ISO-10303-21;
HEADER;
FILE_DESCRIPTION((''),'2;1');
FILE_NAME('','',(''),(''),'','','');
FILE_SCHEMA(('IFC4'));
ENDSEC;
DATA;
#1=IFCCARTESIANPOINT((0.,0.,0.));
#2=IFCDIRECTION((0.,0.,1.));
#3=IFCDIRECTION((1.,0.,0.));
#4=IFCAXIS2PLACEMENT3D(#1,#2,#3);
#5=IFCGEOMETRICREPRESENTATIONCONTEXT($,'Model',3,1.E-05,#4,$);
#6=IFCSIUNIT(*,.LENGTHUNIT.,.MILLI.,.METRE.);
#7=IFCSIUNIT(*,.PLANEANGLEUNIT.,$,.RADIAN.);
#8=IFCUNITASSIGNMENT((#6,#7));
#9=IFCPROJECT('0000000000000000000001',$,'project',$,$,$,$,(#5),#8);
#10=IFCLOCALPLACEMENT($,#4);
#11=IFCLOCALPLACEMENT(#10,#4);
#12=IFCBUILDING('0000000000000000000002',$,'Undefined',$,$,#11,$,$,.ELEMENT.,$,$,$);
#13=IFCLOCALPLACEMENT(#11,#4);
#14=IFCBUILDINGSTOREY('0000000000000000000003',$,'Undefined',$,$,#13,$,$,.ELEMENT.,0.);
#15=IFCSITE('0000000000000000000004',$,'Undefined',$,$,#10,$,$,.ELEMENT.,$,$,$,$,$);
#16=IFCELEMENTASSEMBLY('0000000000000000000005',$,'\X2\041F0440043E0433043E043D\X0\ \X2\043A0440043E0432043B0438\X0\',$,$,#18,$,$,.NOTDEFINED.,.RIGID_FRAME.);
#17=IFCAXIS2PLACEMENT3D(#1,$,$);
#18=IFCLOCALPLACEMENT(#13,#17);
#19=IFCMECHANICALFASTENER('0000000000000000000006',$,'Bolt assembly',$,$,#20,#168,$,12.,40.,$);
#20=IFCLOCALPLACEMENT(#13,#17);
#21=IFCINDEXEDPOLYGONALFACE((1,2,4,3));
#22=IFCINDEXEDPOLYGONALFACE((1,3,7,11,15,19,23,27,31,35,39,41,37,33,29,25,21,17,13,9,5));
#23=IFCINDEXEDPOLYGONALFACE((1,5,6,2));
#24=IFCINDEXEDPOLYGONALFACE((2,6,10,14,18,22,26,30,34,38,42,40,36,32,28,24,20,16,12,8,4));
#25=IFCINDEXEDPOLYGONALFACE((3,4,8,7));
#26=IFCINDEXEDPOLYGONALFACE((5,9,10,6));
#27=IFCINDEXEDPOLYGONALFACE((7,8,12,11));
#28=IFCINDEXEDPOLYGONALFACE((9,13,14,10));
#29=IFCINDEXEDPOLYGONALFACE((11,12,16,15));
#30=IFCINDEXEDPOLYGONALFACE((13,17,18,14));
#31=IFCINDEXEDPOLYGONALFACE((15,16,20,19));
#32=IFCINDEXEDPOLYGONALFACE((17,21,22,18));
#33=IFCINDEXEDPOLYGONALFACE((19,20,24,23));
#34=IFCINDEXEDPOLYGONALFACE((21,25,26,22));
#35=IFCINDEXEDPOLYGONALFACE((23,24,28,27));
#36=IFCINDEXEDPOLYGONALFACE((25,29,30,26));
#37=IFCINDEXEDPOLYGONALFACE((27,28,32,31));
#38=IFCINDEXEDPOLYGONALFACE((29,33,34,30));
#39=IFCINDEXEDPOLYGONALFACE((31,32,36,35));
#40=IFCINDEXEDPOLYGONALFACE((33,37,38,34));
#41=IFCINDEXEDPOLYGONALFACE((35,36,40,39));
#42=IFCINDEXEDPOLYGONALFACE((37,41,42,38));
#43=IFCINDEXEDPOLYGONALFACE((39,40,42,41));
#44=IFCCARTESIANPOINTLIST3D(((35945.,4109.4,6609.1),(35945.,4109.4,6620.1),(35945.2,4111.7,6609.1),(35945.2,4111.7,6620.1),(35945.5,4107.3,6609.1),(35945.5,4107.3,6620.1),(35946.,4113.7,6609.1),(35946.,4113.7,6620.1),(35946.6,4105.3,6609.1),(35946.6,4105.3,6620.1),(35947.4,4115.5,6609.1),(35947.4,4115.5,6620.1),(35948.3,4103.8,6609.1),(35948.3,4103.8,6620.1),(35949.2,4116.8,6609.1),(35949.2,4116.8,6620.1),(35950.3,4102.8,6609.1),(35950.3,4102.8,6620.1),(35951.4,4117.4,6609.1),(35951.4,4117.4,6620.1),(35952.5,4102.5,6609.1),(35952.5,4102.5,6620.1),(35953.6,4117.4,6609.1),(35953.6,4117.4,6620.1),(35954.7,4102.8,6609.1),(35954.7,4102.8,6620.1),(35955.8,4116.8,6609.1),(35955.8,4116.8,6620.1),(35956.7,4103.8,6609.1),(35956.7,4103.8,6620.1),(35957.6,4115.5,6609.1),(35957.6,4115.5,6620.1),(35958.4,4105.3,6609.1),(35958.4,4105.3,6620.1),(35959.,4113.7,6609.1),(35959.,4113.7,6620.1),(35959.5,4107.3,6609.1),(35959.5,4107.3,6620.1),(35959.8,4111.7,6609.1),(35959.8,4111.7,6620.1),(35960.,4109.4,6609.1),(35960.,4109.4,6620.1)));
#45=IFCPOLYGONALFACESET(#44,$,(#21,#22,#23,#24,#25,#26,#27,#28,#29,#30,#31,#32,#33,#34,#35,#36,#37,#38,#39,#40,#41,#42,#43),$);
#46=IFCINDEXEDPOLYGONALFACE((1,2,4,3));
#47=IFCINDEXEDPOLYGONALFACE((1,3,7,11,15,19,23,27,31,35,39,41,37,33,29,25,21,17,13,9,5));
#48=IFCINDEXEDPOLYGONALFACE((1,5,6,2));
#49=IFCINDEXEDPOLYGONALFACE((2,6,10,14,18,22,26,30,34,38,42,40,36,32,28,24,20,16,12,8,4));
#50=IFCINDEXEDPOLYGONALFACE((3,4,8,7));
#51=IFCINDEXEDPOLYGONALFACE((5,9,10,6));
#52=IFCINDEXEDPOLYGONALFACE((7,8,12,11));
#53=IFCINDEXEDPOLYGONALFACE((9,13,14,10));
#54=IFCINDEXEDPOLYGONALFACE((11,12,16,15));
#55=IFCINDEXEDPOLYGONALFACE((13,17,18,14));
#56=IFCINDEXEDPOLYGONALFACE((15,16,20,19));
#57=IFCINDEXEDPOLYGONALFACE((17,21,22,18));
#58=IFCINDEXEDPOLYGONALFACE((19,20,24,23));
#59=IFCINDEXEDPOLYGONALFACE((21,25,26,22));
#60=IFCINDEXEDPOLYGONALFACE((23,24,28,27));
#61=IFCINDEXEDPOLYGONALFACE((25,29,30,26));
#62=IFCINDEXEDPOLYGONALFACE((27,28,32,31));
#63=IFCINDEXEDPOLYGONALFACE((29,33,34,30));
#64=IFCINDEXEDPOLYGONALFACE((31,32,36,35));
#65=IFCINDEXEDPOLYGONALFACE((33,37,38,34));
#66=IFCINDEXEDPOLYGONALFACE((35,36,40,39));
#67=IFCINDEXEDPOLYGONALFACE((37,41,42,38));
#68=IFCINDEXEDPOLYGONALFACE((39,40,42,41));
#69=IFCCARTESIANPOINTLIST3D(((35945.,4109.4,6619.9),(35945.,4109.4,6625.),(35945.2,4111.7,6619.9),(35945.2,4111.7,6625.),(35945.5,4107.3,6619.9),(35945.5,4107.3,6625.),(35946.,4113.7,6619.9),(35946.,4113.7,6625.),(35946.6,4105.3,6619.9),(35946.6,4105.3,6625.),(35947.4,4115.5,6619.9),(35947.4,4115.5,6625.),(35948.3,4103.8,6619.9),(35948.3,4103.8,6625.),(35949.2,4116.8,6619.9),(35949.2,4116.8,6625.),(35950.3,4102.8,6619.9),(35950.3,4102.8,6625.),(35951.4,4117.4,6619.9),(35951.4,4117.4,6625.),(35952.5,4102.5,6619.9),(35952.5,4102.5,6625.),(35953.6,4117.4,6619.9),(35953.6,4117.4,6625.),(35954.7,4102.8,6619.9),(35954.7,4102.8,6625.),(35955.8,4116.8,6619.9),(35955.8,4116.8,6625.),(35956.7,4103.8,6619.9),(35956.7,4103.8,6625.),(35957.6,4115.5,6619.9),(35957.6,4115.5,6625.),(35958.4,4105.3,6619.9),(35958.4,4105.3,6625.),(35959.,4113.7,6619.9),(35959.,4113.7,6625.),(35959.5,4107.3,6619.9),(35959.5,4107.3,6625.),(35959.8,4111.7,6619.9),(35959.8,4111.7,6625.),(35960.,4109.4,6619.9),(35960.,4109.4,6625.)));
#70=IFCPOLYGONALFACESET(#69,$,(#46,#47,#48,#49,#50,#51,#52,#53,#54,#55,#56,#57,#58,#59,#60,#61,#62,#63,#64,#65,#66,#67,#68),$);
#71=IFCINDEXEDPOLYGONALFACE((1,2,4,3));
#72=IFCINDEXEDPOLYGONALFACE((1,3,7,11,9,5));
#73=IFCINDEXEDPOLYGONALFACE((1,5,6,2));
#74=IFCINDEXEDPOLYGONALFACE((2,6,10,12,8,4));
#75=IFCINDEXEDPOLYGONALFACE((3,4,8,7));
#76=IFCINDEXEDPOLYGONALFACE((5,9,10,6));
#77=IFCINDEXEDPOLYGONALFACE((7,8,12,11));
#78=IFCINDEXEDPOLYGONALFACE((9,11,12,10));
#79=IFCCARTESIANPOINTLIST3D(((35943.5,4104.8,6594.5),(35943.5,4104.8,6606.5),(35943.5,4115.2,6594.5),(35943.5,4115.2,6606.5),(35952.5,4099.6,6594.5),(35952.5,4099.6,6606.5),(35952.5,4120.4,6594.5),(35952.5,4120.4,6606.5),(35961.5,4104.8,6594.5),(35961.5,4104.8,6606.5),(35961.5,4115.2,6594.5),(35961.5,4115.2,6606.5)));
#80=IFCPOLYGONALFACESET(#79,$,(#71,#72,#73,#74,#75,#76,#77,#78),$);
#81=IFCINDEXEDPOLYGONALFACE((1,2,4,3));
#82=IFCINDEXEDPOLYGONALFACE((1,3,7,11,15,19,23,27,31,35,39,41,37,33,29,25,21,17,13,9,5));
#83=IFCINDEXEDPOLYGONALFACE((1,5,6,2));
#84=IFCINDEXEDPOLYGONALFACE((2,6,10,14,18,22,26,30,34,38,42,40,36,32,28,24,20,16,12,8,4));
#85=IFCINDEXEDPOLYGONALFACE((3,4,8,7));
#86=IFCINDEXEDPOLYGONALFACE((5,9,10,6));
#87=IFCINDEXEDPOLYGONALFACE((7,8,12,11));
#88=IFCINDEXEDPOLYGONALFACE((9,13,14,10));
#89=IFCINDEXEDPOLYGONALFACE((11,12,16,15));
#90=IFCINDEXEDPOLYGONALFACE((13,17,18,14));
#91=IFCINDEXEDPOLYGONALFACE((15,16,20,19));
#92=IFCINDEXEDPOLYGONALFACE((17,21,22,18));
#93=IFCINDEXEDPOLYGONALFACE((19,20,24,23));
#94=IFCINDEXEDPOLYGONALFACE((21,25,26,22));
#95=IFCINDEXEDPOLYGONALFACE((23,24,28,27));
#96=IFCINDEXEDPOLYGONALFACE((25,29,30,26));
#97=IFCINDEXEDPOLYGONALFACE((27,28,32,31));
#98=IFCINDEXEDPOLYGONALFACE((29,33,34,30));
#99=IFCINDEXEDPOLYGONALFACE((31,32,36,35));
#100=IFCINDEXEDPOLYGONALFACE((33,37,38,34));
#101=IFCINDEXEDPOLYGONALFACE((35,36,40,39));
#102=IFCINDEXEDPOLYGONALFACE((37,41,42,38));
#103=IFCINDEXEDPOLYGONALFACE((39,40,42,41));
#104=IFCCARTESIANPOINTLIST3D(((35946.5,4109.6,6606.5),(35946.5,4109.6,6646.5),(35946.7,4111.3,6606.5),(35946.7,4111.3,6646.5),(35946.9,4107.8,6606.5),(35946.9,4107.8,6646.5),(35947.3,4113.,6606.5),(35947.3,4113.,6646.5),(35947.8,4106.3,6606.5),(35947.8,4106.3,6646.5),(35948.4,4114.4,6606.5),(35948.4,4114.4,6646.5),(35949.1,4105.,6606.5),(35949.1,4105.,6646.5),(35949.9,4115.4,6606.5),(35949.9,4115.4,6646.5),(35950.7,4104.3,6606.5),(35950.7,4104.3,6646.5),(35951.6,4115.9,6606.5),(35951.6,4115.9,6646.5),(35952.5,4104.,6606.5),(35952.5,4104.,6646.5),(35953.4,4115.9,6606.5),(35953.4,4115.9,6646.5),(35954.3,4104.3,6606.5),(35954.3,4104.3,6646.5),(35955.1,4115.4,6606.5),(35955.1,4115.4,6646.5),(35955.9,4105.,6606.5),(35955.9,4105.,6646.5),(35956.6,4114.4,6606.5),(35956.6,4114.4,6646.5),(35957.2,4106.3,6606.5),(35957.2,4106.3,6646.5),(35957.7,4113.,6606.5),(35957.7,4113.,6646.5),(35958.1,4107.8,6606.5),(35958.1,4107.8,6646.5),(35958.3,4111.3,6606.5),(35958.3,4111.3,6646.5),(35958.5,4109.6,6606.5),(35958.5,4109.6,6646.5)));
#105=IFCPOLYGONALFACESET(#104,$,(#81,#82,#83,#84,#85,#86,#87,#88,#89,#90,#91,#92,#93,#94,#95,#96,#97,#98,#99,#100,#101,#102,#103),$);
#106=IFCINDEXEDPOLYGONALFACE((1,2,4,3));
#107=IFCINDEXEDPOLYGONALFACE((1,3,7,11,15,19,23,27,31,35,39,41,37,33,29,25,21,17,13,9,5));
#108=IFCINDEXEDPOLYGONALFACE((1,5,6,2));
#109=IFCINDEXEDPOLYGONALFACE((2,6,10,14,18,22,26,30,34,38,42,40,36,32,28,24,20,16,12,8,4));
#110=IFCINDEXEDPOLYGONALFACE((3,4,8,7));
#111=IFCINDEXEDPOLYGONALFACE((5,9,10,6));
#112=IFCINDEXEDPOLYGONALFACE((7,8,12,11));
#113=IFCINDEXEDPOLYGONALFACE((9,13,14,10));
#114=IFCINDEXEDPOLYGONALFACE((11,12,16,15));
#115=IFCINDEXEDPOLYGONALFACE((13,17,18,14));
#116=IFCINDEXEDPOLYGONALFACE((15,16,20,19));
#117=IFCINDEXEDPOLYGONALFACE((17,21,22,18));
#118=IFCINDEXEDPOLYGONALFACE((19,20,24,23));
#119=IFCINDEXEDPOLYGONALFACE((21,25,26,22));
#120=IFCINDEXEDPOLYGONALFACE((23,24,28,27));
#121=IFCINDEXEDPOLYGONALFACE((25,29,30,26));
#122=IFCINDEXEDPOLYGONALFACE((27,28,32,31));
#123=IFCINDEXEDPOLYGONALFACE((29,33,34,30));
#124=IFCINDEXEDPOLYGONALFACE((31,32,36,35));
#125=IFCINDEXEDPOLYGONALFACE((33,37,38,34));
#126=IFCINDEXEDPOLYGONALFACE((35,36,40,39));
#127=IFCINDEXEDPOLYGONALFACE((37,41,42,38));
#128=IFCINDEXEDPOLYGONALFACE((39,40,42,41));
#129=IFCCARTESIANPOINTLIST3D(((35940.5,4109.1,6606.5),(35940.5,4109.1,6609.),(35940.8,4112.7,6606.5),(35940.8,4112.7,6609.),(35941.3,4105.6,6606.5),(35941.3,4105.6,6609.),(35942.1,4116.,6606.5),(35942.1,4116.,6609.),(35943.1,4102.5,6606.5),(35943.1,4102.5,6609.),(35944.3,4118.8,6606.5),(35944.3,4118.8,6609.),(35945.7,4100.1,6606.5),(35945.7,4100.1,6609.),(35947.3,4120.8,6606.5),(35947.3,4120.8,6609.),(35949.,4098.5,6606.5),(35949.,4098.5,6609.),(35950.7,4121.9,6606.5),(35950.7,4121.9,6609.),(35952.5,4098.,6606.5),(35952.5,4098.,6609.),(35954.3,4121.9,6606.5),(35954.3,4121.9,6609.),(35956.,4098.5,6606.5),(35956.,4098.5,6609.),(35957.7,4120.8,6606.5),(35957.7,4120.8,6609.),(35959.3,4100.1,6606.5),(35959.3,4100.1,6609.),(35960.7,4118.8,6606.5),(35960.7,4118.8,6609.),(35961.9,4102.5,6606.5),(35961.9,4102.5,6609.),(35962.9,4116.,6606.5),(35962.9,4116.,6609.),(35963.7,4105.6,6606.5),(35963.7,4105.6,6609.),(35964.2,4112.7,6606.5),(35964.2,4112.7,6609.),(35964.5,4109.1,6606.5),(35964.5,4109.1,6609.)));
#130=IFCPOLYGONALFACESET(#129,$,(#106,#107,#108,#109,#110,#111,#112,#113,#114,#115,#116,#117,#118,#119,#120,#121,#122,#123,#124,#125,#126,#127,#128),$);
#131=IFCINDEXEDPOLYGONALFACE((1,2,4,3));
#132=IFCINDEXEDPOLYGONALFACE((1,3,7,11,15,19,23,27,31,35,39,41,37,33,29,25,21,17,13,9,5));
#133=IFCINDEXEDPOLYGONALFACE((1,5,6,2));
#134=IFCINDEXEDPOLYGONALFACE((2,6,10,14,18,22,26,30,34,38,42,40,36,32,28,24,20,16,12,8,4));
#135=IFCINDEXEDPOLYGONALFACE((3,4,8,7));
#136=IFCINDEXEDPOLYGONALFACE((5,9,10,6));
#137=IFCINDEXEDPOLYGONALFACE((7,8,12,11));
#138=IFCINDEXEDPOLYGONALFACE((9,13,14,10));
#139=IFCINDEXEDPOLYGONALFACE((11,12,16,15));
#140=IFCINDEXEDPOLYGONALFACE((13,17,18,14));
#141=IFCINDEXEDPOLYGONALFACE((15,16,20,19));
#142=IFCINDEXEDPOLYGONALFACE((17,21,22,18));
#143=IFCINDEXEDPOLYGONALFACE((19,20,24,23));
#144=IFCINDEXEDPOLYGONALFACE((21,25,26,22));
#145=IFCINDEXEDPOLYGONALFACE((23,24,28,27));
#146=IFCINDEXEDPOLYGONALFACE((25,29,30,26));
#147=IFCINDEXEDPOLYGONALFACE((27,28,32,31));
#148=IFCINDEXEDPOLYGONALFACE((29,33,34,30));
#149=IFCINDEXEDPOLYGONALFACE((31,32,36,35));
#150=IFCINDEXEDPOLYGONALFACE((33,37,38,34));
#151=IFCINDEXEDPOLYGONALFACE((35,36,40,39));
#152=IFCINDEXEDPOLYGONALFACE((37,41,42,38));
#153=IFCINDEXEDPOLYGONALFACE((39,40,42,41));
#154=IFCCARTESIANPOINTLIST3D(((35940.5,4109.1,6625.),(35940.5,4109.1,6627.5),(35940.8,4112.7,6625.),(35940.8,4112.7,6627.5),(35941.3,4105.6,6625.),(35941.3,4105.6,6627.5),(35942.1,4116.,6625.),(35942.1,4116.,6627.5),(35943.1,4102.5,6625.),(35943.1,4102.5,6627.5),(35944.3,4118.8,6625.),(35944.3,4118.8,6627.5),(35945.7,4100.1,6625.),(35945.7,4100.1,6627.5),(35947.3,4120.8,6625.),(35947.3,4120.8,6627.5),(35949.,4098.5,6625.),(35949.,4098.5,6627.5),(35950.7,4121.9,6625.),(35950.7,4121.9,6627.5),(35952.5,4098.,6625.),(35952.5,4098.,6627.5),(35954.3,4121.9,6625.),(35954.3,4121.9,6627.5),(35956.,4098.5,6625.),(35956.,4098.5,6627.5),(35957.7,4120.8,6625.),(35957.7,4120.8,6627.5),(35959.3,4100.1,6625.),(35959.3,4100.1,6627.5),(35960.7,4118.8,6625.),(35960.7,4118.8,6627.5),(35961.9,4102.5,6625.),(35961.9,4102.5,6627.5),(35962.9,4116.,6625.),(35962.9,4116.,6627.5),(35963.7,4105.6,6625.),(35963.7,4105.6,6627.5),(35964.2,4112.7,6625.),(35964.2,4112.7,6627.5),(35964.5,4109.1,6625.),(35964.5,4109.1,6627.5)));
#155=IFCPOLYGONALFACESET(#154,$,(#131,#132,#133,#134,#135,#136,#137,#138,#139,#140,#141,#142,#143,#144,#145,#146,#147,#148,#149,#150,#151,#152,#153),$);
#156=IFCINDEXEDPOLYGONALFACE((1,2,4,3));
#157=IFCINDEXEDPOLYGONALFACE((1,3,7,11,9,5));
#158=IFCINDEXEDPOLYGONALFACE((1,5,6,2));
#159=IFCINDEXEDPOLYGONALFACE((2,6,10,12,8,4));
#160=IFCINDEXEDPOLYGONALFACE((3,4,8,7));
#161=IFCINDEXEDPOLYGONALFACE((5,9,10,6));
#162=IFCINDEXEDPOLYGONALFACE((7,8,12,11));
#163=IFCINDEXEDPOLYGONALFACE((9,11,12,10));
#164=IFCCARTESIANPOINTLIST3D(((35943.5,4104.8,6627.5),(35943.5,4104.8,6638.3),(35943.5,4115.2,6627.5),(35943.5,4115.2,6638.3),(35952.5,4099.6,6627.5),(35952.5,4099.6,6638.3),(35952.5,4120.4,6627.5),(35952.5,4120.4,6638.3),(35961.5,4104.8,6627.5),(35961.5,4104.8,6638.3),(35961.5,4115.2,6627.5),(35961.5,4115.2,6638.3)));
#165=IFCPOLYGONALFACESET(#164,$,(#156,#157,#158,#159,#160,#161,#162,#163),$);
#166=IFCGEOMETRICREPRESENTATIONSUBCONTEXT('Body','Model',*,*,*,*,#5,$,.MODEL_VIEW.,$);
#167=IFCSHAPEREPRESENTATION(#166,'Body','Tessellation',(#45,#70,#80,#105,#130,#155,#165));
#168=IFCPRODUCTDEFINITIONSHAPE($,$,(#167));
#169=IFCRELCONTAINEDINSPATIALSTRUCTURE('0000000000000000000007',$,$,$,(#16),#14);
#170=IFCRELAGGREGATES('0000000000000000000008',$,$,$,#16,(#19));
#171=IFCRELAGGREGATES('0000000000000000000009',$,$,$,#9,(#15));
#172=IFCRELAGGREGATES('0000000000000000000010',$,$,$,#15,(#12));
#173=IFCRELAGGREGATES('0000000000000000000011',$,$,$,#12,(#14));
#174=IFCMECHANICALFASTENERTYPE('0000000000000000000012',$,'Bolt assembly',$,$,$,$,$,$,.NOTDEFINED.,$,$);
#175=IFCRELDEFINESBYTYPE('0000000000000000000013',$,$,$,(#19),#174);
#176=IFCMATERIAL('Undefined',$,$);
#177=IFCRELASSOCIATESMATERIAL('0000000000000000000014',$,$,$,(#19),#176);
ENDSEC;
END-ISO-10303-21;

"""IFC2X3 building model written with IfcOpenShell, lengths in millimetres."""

from ifc_helpers import new_model, si_unit, frame, origin_with_axes, origin_2d_with_axis, place, context, subcontext, project, spatial, polyline, circle, outline, extrude, source, transform, mapped, material, type_object, element, aggregate, save


model = new_model("IFC2X3")

# Units and contexts
model_context = context("Model", 3, precision=1e-05, world=origin_with_axes())
body_context = subcontext(model_context, "Body", "Model", "MODEL_VIEW")
ifc_project = project(units=[si_unit("LENGTHUNIT", "METRE", prefix="MILLI"), si_unit("PLANEANGLEUNIT", "RADIAN")], contexts=[model_context])

# Site, building, storey
site_placement = place(None, origin_with_axes())
site = spatial("IfcSite", under=ifc_project, at=site_placement, Name="Undefined", CompositionType="ELEMENT")
building_placement = place(site_placement, origin_with_axes())
building = spatial("IfcBuilding", under=site, at=building_placement, Name="Undefined", CompositionType="ELEMENT")
storey_placement = place(building_placement, origin_with_axes())
storey = spatial("IfcBuildingStorey", under=building, at=storey_placement, Name="Undefined", CompositionType="ELEMENT", Elevation=0.0)

# Element assembly
assembly_1_placement = place(storey_placement, origin_with_axes())
assembly_1 = element("IfcElementAssembly", 1, at=assembly_1_placement, inside=storey, Name="Прогон кровли", AssemblyPlace="NOTDEFINED", PredefinedType="RIGID_FRAME")

# Mechanical fastener
ifc_material_1 = material(Name="Undefined")
mechanical_fastener_type = type_object("IfcMechanicalFastenerType", Name="Bolt assembly")
shared_shape_1 = source(origin_with_axes(), body_context, "Body", "SweptSolid", [
    extrude(circle(Radius=7.5, at=origin_2d_with_axis()), frame((0.0, -10.9, 0.0), z_axis=(0.0, 1.0, 0.0), x_axis=(1.0, 0.0, 0.0)), (0.0, 0.0, 1.0), 11.0),
    extrude(circle(Radius=7.5, at=origin_2d_with_axis()), frame((0.0, -0.1, 0.0), z_axis=(0.0, 1.0, 0.0), x_axis=(1.0, 0.0, 0.0)), (0.0, 0.0, 1.0), 5.1),
    extrude(outline(polyline([(10.4, 0.0), (5.2, 9.0), (-5.2, 9.0), (-10.4, 0.0), (-5.2, -9.0), (5.2, -9.0), (10.4, 0.0)])), frame((0.0, -25.5, 0.0), z_axis=(0.0, 1.0, 0.0), x_axis=(1.0, 0.0, 0.0)), (0.0, 0.0, 1.0), 12.0),
    extrude(circle(Radius=6.0, at=origin_2d_with_axis()), frame((0.0, -13.5, 0.0), z_axis=(0.0, 1.0, 0.0), x_axis=(1.0, 0.0, 0.0)), (0.0, 0.0, 1.0), 40.0),
    extrude(circle(Radius=12.0, at=origin_2d_with_axis()), frame((0.0, -13.5, 0.0), z_axis=(0.0, 1.0, 0.0), x_axis=(1.0, 0.0, 0.0)), (0.0, 0.0, 1.0), 2.5),
    extrude(circle(Radius=12.0, at=origin_2d_with_axis()), frame((0.0, 5.0, 0.0), z_axis=(0.0, 1.0, 0.0), x_axis=(1.0, 0.0, 0.0)), (0.0, 0.0, 1.0), 2.5),
    extrude(outline(polyline([(10.4, 0.0), (5.2, 9.0), (-5.2, 9.0), (-10.4, 0.0), (-5.2, -9.0), (5.2, -9.0), (10.4, 0.0)])), frame((0.0, 7.5, 0.0), z_axis=(0.0, 1.0, 0.0), x_axis=(1.0, 0.0, 0.0)), (0.0, 0.0, 1.0), 10.8),
])
mechanical_fastener_1_placement = place(assembly_1_placement, frame((35952.5, 4110.0, 6620.0), z_axis=(-1.0, 0.0, 0.0), x_axis=(0.0, -1.0, 0.0)))
mechanical_fastener_1 = element("IfcMechanicalFastener", 2, at=mechanical_fastener_1_placement, type_object=mechanical_fastener_type, material=ifc_material_1, Name="Bolt assembly", NominalDiameter=12.0, NominalLength=40.0, context=body_context, shape_type="MappedRepresentation", body=[
    mapped(shared_shape_1, transform((0.0, 0.0, 0.0))),
])
aggregate(assembly_1, [mechanical_fastener_1])

save(model, "model.ifc")
